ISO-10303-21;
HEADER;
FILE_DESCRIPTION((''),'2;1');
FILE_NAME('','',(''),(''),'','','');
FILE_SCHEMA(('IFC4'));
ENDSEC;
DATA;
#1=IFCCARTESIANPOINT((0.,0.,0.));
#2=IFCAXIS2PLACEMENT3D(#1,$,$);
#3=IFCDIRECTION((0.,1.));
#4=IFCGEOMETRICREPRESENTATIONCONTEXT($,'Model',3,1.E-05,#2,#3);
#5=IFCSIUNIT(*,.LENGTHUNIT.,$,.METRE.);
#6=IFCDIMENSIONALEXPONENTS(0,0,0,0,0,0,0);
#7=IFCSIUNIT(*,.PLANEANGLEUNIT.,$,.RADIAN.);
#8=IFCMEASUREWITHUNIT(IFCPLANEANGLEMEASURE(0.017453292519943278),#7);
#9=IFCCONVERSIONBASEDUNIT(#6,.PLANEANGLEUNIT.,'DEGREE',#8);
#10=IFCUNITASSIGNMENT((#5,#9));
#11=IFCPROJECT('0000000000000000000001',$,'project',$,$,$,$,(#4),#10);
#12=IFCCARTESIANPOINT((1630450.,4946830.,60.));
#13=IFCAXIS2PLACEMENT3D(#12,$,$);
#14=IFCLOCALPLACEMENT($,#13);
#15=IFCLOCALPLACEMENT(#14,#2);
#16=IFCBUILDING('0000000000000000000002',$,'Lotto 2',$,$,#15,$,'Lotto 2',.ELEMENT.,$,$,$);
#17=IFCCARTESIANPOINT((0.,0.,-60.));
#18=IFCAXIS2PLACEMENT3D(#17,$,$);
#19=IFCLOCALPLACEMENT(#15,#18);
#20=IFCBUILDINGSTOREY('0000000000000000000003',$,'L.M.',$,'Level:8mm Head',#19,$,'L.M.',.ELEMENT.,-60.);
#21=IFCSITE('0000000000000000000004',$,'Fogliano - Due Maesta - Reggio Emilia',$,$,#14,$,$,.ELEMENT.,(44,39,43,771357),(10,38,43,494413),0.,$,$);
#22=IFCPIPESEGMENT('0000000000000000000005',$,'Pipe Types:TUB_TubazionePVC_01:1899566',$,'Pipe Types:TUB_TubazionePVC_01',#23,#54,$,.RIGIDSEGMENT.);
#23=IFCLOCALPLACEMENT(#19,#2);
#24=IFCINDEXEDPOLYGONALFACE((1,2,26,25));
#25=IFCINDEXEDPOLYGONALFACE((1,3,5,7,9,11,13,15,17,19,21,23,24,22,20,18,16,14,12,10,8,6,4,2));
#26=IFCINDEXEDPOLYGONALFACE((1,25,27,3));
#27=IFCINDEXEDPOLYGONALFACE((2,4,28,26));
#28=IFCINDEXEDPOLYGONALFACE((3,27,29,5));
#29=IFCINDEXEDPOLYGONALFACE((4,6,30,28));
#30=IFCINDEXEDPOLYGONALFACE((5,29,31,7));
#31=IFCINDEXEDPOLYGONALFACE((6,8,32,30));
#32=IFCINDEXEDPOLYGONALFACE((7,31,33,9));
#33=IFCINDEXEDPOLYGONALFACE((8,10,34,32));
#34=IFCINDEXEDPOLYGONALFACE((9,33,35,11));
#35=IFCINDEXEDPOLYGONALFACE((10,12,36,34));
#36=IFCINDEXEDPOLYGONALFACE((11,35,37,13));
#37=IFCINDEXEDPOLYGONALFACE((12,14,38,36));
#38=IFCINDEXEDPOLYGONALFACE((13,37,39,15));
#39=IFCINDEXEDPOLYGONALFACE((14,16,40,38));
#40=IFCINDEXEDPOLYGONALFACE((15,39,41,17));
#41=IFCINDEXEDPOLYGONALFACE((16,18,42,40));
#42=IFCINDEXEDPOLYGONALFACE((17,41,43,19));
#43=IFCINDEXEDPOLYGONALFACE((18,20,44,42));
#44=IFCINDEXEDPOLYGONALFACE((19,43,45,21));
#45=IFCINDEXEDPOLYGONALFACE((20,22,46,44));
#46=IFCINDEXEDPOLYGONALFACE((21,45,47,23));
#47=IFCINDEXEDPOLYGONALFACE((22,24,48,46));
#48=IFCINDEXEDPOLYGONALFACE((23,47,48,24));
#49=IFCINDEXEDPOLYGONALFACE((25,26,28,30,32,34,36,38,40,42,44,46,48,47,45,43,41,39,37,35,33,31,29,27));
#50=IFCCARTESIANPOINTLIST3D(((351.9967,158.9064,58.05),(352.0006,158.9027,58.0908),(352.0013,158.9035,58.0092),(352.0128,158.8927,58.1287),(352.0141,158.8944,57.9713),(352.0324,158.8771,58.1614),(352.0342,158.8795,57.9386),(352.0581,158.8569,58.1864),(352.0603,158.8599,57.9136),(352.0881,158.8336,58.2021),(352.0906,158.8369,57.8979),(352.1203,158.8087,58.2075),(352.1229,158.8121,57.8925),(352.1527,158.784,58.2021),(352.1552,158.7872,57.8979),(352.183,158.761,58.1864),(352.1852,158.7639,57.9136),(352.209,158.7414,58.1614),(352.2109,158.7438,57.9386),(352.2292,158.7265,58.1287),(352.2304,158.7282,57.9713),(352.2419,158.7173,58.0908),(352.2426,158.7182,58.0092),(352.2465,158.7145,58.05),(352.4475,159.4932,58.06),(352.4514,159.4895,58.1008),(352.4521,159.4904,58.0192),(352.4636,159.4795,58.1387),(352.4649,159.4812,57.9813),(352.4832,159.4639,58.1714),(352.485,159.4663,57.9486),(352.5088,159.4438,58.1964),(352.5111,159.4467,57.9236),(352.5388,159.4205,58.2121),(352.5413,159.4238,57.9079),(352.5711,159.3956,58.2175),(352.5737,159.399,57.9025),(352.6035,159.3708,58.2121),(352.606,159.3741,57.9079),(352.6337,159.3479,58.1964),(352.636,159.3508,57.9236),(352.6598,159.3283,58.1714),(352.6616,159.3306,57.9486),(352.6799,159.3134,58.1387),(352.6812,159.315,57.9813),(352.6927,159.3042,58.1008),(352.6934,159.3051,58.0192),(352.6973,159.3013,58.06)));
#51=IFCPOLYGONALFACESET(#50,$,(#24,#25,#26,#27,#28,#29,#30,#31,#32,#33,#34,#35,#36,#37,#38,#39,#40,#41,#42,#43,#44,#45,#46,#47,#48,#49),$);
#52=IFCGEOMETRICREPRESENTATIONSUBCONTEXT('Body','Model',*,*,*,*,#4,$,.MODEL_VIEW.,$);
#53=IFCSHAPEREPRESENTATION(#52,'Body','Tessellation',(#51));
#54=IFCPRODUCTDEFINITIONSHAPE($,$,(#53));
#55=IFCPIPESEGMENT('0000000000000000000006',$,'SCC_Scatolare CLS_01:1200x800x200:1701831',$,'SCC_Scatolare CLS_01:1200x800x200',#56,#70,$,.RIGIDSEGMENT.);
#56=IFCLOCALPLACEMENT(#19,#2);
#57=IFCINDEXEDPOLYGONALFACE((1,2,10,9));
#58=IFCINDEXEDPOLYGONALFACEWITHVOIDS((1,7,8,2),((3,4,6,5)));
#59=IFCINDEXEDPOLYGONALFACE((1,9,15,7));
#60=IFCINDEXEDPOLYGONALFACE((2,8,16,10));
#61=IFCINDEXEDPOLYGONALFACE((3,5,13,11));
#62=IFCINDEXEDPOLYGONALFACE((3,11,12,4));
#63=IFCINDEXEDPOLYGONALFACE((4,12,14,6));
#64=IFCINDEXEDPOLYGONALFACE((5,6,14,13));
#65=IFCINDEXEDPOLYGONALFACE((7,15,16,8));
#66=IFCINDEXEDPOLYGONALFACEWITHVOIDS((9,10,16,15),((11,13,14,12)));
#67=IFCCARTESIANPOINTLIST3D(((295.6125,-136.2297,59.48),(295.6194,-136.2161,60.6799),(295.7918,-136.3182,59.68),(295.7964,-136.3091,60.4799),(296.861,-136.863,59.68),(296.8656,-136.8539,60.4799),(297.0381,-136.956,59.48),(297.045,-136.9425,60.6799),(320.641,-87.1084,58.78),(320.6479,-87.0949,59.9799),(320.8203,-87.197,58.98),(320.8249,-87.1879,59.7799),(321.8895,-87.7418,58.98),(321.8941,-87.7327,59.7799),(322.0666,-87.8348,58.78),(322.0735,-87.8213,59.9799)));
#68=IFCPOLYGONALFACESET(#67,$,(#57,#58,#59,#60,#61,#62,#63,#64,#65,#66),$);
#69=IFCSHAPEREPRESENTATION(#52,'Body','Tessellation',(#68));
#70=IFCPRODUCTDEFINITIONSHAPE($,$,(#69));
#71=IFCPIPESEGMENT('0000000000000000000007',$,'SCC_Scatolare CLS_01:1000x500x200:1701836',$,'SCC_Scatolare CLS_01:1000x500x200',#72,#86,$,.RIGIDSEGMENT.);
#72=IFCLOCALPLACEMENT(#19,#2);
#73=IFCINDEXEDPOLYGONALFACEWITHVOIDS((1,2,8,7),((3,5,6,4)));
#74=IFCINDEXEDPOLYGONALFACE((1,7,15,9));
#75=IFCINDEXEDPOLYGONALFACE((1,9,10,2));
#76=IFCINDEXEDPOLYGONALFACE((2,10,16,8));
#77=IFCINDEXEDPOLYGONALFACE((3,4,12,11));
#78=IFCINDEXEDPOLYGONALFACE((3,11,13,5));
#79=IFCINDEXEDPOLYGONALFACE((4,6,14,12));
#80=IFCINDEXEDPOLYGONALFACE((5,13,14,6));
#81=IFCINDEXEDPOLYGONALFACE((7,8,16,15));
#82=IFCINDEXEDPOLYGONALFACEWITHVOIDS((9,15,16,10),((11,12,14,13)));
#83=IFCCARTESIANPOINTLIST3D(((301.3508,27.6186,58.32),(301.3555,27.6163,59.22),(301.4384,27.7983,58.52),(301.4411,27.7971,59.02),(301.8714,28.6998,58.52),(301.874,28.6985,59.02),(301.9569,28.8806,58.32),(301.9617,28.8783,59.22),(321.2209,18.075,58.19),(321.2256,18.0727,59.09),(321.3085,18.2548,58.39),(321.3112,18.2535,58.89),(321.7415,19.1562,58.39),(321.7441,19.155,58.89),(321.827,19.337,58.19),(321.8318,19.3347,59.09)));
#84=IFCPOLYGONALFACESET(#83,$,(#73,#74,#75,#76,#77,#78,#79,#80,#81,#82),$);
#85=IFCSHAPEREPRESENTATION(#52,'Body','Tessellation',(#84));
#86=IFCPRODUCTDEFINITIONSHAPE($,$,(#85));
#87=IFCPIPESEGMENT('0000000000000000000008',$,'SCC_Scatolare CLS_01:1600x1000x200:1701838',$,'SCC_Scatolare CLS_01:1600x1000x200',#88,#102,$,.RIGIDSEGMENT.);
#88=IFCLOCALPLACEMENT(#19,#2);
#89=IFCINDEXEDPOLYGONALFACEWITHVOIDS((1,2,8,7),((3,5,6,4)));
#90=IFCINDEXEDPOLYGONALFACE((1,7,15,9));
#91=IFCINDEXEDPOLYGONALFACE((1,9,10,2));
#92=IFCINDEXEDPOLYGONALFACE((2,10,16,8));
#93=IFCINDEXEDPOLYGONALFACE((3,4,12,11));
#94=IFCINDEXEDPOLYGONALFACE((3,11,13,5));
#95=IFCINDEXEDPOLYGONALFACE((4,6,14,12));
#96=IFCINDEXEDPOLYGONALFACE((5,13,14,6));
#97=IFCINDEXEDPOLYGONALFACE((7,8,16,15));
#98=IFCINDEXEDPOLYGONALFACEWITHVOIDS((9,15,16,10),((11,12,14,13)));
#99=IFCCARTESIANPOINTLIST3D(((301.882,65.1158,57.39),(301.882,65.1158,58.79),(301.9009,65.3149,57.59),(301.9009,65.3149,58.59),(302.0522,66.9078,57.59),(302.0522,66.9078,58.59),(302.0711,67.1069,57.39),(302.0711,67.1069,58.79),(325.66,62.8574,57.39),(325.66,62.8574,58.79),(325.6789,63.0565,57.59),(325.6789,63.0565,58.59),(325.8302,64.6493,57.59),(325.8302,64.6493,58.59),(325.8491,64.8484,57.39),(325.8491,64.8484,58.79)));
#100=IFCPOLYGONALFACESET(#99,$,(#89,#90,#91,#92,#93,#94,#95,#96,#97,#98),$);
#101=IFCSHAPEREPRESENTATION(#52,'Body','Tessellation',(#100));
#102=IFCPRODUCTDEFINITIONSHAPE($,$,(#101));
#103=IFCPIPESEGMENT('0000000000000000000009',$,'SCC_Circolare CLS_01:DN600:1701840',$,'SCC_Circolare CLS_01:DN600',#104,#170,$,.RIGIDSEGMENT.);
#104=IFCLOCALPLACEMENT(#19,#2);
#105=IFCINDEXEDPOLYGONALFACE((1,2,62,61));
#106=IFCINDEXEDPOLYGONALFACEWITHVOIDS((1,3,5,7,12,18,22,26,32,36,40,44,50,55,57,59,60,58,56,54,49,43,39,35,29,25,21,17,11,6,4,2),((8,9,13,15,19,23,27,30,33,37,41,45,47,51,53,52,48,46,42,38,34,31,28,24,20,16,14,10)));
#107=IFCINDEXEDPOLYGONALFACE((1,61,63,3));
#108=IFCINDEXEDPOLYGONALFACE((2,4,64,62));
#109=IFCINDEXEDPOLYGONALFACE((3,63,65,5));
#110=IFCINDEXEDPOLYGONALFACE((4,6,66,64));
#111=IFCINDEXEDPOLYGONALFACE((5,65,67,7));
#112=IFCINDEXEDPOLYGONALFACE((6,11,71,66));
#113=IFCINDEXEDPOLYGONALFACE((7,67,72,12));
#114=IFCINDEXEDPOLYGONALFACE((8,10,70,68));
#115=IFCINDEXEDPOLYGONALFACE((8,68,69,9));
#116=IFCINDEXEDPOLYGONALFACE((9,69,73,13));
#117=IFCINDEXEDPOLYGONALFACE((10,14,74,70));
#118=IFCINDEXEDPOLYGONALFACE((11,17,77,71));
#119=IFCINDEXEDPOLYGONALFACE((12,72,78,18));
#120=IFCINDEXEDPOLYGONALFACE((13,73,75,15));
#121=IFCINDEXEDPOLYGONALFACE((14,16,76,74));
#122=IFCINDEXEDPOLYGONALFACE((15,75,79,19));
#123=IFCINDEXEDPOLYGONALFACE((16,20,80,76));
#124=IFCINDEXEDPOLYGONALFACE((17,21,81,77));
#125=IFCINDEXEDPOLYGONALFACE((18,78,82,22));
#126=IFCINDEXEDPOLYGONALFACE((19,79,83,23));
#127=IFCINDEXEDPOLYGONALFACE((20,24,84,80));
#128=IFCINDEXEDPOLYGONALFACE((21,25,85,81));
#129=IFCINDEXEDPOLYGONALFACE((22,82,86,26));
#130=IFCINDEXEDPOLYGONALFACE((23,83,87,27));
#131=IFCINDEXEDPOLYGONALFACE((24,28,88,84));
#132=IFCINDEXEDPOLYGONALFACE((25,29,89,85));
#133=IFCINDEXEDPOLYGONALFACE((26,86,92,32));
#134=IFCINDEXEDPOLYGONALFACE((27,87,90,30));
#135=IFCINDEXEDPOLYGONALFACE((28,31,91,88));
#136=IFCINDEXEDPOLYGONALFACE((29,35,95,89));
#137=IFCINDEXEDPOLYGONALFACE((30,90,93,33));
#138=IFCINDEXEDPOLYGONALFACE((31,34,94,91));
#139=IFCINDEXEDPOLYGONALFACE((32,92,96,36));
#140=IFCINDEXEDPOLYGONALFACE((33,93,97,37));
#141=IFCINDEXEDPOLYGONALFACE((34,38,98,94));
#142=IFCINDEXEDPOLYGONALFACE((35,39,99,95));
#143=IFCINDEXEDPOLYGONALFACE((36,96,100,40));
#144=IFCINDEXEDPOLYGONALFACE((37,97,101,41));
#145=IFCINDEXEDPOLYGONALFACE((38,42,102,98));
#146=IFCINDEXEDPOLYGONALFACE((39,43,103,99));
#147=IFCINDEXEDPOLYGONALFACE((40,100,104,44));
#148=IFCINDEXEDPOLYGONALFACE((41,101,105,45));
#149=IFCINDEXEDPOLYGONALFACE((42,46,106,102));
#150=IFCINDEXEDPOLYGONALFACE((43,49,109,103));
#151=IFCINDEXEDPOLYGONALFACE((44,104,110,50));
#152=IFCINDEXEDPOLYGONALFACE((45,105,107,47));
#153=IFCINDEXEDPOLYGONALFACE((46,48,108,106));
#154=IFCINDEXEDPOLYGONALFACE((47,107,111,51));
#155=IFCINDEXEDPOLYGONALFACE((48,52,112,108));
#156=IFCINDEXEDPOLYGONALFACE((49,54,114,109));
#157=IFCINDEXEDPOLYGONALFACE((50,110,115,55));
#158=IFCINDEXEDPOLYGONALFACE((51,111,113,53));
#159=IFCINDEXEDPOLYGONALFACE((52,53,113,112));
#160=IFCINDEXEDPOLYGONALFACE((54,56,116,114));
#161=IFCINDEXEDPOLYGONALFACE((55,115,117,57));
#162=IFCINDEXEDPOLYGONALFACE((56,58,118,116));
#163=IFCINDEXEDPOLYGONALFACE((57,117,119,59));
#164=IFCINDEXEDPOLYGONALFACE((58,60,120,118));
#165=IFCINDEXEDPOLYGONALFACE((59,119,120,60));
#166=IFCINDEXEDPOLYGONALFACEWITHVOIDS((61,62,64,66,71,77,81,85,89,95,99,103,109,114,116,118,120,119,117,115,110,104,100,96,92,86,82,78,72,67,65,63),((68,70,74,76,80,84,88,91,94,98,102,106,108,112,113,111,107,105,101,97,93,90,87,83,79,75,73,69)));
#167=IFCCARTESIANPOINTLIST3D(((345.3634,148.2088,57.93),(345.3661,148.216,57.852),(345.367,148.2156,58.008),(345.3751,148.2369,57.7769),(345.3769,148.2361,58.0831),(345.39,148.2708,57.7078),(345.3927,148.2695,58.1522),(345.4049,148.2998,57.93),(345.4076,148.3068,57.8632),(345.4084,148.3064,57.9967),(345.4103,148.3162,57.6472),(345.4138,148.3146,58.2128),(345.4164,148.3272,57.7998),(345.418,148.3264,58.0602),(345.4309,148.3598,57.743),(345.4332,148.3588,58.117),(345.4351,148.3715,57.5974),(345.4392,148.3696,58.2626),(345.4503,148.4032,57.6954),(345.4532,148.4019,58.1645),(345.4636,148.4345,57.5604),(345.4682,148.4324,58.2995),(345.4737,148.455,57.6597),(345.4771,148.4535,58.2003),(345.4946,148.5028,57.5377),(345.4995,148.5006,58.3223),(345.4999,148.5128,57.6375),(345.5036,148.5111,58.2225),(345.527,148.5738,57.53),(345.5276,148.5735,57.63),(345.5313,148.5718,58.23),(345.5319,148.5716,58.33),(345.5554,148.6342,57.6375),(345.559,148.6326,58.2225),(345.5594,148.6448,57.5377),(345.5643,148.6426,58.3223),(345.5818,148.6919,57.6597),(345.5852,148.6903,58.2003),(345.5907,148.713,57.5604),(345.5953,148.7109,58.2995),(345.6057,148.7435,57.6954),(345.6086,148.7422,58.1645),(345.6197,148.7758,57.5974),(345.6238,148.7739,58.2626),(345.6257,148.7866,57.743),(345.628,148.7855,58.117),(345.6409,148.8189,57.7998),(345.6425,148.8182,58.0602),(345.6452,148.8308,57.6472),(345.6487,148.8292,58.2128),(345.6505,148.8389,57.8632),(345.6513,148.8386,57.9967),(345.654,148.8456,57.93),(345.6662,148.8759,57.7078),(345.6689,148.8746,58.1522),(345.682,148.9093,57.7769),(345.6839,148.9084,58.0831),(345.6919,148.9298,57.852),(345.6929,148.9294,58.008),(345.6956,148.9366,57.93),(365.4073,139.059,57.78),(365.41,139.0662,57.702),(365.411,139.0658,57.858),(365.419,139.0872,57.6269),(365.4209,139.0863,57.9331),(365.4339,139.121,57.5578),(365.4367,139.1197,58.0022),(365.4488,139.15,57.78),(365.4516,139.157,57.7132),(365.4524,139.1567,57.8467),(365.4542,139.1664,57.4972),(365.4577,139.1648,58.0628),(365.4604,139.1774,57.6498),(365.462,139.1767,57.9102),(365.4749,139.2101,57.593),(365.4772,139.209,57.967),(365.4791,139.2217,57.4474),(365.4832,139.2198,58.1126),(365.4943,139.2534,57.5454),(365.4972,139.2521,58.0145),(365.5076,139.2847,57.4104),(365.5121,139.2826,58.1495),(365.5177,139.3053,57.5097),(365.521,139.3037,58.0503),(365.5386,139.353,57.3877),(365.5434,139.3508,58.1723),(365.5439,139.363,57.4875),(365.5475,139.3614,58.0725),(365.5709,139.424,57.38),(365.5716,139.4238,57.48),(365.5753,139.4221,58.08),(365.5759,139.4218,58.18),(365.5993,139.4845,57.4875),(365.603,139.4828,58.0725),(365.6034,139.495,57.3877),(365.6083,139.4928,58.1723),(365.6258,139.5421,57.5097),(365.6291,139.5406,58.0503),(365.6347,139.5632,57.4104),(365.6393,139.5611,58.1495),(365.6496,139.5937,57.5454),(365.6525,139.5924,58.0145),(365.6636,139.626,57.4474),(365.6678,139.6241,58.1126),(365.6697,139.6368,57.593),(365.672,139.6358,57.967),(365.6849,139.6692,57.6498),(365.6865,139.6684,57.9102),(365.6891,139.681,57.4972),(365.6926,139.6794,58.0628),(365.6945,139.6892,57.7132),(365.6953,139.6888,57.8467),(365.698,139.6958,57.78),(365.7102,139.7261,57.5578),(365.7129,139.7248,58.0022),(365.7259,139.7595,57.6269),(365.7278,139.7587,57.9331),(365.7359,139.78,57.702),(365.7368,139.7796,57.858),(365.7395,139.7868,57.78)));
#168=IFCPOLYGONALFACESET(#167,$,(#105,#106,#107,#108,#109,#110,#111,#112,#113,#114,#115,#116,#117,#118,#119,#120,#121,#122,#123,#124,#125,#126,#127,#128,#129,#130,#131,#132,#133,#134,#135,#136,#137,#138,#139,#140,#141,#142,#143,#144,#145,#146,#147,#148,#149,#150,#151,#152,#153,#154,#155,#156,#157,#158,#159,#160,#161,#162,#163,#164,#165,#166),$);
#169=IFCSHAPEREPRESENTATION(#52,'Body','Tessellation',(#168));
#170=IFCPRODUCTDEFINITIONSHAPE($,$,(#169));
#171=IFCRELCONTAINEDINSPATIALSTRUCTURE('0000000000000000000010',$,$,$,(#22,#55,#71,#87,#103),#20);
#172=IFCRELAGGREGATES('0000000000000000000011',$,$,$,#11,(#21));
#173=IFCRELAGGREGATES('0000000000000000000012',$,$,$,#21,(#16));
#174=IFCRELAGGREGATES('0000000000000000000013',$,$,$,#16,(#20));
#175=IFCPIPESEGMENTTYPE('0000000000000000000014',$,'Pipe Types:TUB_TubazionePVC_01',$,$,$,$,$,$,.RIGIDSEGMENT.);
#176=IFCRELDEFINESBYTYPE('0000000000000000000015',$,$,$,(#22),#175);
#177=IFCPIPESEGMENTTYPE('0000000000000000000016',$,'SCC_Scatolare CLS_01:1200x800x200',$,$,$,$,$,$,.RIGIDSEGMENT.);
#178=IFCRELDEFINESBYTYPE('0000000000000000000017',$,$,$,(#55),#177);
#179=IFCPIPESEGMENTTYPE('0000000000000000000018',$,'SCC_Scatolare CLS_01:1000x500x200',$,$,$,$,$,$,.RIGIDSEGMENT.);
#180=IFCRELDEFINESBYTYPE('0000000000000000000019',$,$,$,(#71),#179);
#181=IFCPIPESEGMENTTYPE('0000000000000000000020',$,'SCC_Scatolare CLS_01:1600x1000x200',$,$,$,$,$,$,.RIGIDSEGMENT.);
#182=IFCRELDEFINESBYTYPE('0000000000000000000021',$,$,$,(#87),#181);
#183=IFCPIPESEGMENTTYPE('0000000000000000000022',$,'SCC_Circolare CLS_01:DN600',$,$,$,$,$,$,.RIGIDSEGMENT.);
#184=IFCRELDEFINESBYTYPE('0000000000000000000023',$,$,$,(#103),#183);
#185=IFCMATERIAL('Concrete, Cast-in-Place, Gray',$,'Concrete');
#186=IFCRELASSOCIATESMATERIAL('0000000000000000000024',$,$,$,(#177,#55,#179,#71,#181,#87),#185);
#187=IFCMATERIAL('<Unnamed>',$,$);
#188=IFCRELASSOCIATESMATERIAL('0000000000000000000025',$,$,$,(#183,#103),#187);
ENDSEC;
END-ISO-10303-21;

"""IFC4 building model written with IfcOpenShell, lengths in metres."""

from ifc_helpers import new_model, entity, si_unit, converted_unit, direction, frame, origin, place, context, subcontext, project, spatial, arc, indexed_curve, outline, extrude, source, transform, mapped, material, type_object, type_shapes, element, save


model = new_model("IFC4")

# Units and contexts
model_context = context("Model", 3, precision=1e-05, world=origin(), true_north=direction((0.0, 1.0)))
body_context = subcontext(model_context, "Body", "Model", "MODEL_VIEW")
ifc_project = project(units=[si_unit("LENGTHUNIT", "METRE"), converted_unit("PLANEANGLEUNIT", "DEGREE", entity("IfcPlaneAngleMeasure", 0.017453292519943278), si_unit("PLANEANGLEUNIT", "RADIAN"), dimensions=[0, 0, 0, 0, 0, 0, 0])], contexts=[model_context])

# Site, building, storey
site_placement = place(None, frame((1630450.0, 4946830.0, 60.0)))
site = spatial("IfcSite", under=ifc_project, at=site_placement, Name="Fogliano - Due Maesta - Reggio Emilia", CompositionType="ELEMENT", RefLatitude=(44, 39, 43, 771357), RefLongitude=(10, 38, 43, 494413), RefElevation=0.0)
building_placement = place(site_placement, origin())
building = spatial("IfcBuilding", under=site, at=building_placement, Name="Lotto 2", LongName="Lotto 2", CompositionType="ELEMENT")
storey_placement = place(building_placement, frame((0.0, 0.0, -60.0)))
storey = spatial("IfcBuildingStorey", under=building, at=storey_placement, Name="L.M.", ObjectType="Level:8mm Head", LongName="L.M.", CompositionType="ELEMENT", Elevation=-60.0)

# Pipe segments
pipe_segment_type_1 = type_object("IfcPipeSegmentType", Name="Pipe Types:TUB_TubazionePVC_01", PredefinedType="RIGIDSEGMENT")
pipe_segment_1_placement = place(storey_placement, origin())
element("IfcPipeSegment", 1, at=pipe_segment_1_placement, inside=storey, type_object=pipe_segment_type_1, Name="Pipe Types:TUB_TubazionePVC_01:1899566", ObjectType="Pipe Types:TUB_TubazionePVC_01", PredefinedType="RIGIDSEGMENT", context=body_context, shape_type="SweptSolid", body=[
    extrude(outline(indexed_curve([(0.1575, 0.0), (0.1114, 0.1114), (0.0, 0.1575), (-0.1114, 0.1114), (-0.1575, 0.0), (-0.1114, -0.1114), (0.0, -0.1575), (0.1114, -0.1114)], segments=[arc(1, 2, 3), arc(3, 4, 5), arc(5, 6, 7), arc(7, 8, 1)], self_intersect=False)), frame((352.1216, 158.8104, 58.05), z_axis=(0.609108, 0.792972, 0.013512), x_axis=(-0.793045, 0.609163, 0.0)), (0.0, 0.0, 1.0), 0.7401),
])
ifc_material_1 = material(Name="Concrete, Cast-in-Place, Gray", Category="Concrete")
pipe_segment_type_2 = type_object("IfcPipeSegmentType", Name="SCC_Scatolare CLS_01:1200x800x200", PredefinedType="RIGIDSEGMENT", material=ifc_material_1)
shared_shape_1 = source(origin(), body_context, "Body", "SweptSolid", [
    extrude(outline(indexed_curve([(-0.6, -0.8), (0.6, -0.8), (0.6, 0.8), (-0.6, 0.8), (-0.6, -0.8)], self_intersect=False), holes=[indexed_curve([(-0.4, -0.6), (-0.4, 0.6), (0.4, 0.6), (0.4, -0.6), (-0.4, -0.6)], self_intersect=False)]), frame((-27.5672, 0.0, 0.0), z_axis=(1.0, 0.0, 0.0), x_axis=(0.0, 0.0, -1.0)), (0.0, 0.0, 1.0), 55.1345),
])
type_shapes(pipe_segment_type_2, [shared_shape_1])
pipe_segment_2_placement = place(storey_placement, frame((308.843, -112.0255, 59.73), z_axis=(0.005764, 0.011312, 0.999919), x_axis=(0.453954, 0.890935, -0.012696)))
element("IfcPipeSegment", 2, at=pipe_segment_2_placement, inside=storey, type_object=pipe_segment_type_2, material=ifc_material_1, Name="SCC_Scatolare CLS_01:1200x800x200:1701831", ObjectType="SCC_Scatolare CLS_01:1200x800x200", PredefinedType="RIGIDSEGMENT", context=body_context, shape_type="MappedRepresentation", body=[
    mapped(shared_shape_1, transform((0.0, 0.0, 0.0), scale=1.0)),
])
pipe_segment_type_3 = type_object("IfcPipeSegmentType", Name="SCC_Scatolare CLS_01:1000x500x200", PredefinedType="RIGIDSEGMENT", material=ifc_material_1)
shared_shape_2 = source(origin(), body_context, "Body", "SweptSolid", [
    extrude(outline(indexed_curve([(-0.45, -0.7), (0.45, -0.7), (0.45, 0.7), (-0.45, 0.7), (-0.45, -0.7)], self_intersect=False), holes=[indexed_curve([(-0.25, -0.5), (-0.25, 0.5), (0.25, 0.5), (0.25, -0.5), (-0.25, -0.5)], self_intersect=False)]), frame((-11.0218, 0.0, 0.0), z_axis=(1.0, 0.0, 0.0), x_axis=(0.0, 0.0, -1.0)), (0.0, 0.0, 1.0), 22.0435),
])
type_shapes(pipe_segment_type_3, [shared_shape_2])
pipe_segment_3_placement = place(storey_placement, frame((311.5913, 23.4767, 58.705), z_axis=(0.005316, -0.002553, 0.999983), x_axis=(0.901403, -0.432941, -0.005897)))
element("IfcPipeSegment", 3, at=pipe_segment_3_placement, inside=storey, type_object=pipe_segment_type_3, material=ifc_material_1, Name="SCC_Scatolare CLS_01:1000x500x200:1701836", ObjectType="SCC_Scatolare CLS_01:1000x500x200", PredefinedType="RIGIDSEGMENT", context=body_context, shape_type="MappedRepresentation", body=[
    mapped(shared_shape_2, transform((0.0, 0.0, 0.0), scale=1.0)),
])
pipe_segment_type_4 = type_object("IfcPipeSegmentType", Name="SCC_Scatolare CLS_01:1600x1000x200", PredefinedType="RIGIDSEGMENT", material=ifc_material_1)
shared_shape_3 = source(origin(), body_context, "Body", "SweptSolid", [
    extrude(outline(indexed_curve([(-0.7, -1.0), (0.7, -1.0), (0.7, 1.0), (-0.7, 1.0), (-0.7, -1.0)], self_intersect=False), holes=[indexed_curve([(-0.5, -0.8), (-0.5, 0.8), (0.5, 0.8), (0.5, -0.8), (-0.5, -0.8)], self_intersect=False)]), frame((-11.9425, 0.0, 0.0), z_axis=(1.0, 0.0, 0.0), x_axis=(0.0, 0.0, -1.0)), (0.0, 0.0, 1.0), 23.885),
])
type_shapes(pipe_segment_type_4, [shared_shape_3])
pipe_segment_4_placement = place(storey_placement, frame((313.8656, 64.9821, 58.09), z_axis=(0.0, 0.0, 1.0), x_axis=(0.99552, -0.094555, 0.0)))
element("IfcPipeSegment", 4, at=pipe_segment_4_placement, inside=storey, type_object=pipe_segment_type_4, material=ifc_material_1, Name="SCC_Scatolare CLS_01:1600x1000x200:1701838", ObjectType="SCC_Scatolare CLS_01:1600x1000x200", PredefinedType="RIGIDSEGMENT", context=body_context, shape_type="MappedRepresentation", body=[
    mapped(shared_shape_3, transform((0.0, 0.0, 0.0), scale=1.0)),
])
ifc_material_2 = material(Name="<Unnamed>")
pipe_segment_type_5 = type_object("IfcPipeSegmentType", Name="SCC_Circolare CLS_01:DN600", PredefinedType="RIGIDSEGMENT", material=ifc_material_2)
shared_shape_4 = source(origin(), body_context, "Body", "SweptSolid", [
    extrude(outline(indexed_curve([(0.0, -0.4), (0.4, 0.0), (0.0, 0.4), (-0.4, 0.0)], segments=[arc(1, 2, 3), arc(3, 4, 1)], self_intersect=False), holes=[indexed_curve([(0.0, -0.3), (-0.3, 0.0), (0.0, 0.3), (0.3, 0.0)], segments=[arc(1, 2, 3), arc(3, 4, 1)], self_intersect=False)]), frame((-11.017, 0.0, 0.0), z_axis=(1.0, 0.0, 0.0), x_axis=(0.0, 0.0, -1.0)), (0.0, 0.0, 1.0), 22.0341),
])
type_shapes(pipe_segment_type_5, [shared_shape_4])
pipe_segment_5_placement = place(storey_placement, frame((355.5514, 143.9978, 57.855), z_axis=(0.006193, -0.002827, 0.999977), x_axis=(0.909679, -0.415255, -0.006808)))
element("IfcPipeSegment", 5, at=pipe_segment_5_placement, inside=storey, type_object=pipe_segment_type_5, material=ifc_material_2, Name="SCC_Circolare CLS_01:DN600:1701840", ObjectType="SCC_Circolare CLS_01:DN600", PredefinedType="RIGIDSEGMENT", context=body_context, shape_type="MappedRepresentation", body=[
    mapped(shared_shape_4, transform((0.0, 0.0, 0.0), scale=1.0)),
])

save(model, "model.ifc")
